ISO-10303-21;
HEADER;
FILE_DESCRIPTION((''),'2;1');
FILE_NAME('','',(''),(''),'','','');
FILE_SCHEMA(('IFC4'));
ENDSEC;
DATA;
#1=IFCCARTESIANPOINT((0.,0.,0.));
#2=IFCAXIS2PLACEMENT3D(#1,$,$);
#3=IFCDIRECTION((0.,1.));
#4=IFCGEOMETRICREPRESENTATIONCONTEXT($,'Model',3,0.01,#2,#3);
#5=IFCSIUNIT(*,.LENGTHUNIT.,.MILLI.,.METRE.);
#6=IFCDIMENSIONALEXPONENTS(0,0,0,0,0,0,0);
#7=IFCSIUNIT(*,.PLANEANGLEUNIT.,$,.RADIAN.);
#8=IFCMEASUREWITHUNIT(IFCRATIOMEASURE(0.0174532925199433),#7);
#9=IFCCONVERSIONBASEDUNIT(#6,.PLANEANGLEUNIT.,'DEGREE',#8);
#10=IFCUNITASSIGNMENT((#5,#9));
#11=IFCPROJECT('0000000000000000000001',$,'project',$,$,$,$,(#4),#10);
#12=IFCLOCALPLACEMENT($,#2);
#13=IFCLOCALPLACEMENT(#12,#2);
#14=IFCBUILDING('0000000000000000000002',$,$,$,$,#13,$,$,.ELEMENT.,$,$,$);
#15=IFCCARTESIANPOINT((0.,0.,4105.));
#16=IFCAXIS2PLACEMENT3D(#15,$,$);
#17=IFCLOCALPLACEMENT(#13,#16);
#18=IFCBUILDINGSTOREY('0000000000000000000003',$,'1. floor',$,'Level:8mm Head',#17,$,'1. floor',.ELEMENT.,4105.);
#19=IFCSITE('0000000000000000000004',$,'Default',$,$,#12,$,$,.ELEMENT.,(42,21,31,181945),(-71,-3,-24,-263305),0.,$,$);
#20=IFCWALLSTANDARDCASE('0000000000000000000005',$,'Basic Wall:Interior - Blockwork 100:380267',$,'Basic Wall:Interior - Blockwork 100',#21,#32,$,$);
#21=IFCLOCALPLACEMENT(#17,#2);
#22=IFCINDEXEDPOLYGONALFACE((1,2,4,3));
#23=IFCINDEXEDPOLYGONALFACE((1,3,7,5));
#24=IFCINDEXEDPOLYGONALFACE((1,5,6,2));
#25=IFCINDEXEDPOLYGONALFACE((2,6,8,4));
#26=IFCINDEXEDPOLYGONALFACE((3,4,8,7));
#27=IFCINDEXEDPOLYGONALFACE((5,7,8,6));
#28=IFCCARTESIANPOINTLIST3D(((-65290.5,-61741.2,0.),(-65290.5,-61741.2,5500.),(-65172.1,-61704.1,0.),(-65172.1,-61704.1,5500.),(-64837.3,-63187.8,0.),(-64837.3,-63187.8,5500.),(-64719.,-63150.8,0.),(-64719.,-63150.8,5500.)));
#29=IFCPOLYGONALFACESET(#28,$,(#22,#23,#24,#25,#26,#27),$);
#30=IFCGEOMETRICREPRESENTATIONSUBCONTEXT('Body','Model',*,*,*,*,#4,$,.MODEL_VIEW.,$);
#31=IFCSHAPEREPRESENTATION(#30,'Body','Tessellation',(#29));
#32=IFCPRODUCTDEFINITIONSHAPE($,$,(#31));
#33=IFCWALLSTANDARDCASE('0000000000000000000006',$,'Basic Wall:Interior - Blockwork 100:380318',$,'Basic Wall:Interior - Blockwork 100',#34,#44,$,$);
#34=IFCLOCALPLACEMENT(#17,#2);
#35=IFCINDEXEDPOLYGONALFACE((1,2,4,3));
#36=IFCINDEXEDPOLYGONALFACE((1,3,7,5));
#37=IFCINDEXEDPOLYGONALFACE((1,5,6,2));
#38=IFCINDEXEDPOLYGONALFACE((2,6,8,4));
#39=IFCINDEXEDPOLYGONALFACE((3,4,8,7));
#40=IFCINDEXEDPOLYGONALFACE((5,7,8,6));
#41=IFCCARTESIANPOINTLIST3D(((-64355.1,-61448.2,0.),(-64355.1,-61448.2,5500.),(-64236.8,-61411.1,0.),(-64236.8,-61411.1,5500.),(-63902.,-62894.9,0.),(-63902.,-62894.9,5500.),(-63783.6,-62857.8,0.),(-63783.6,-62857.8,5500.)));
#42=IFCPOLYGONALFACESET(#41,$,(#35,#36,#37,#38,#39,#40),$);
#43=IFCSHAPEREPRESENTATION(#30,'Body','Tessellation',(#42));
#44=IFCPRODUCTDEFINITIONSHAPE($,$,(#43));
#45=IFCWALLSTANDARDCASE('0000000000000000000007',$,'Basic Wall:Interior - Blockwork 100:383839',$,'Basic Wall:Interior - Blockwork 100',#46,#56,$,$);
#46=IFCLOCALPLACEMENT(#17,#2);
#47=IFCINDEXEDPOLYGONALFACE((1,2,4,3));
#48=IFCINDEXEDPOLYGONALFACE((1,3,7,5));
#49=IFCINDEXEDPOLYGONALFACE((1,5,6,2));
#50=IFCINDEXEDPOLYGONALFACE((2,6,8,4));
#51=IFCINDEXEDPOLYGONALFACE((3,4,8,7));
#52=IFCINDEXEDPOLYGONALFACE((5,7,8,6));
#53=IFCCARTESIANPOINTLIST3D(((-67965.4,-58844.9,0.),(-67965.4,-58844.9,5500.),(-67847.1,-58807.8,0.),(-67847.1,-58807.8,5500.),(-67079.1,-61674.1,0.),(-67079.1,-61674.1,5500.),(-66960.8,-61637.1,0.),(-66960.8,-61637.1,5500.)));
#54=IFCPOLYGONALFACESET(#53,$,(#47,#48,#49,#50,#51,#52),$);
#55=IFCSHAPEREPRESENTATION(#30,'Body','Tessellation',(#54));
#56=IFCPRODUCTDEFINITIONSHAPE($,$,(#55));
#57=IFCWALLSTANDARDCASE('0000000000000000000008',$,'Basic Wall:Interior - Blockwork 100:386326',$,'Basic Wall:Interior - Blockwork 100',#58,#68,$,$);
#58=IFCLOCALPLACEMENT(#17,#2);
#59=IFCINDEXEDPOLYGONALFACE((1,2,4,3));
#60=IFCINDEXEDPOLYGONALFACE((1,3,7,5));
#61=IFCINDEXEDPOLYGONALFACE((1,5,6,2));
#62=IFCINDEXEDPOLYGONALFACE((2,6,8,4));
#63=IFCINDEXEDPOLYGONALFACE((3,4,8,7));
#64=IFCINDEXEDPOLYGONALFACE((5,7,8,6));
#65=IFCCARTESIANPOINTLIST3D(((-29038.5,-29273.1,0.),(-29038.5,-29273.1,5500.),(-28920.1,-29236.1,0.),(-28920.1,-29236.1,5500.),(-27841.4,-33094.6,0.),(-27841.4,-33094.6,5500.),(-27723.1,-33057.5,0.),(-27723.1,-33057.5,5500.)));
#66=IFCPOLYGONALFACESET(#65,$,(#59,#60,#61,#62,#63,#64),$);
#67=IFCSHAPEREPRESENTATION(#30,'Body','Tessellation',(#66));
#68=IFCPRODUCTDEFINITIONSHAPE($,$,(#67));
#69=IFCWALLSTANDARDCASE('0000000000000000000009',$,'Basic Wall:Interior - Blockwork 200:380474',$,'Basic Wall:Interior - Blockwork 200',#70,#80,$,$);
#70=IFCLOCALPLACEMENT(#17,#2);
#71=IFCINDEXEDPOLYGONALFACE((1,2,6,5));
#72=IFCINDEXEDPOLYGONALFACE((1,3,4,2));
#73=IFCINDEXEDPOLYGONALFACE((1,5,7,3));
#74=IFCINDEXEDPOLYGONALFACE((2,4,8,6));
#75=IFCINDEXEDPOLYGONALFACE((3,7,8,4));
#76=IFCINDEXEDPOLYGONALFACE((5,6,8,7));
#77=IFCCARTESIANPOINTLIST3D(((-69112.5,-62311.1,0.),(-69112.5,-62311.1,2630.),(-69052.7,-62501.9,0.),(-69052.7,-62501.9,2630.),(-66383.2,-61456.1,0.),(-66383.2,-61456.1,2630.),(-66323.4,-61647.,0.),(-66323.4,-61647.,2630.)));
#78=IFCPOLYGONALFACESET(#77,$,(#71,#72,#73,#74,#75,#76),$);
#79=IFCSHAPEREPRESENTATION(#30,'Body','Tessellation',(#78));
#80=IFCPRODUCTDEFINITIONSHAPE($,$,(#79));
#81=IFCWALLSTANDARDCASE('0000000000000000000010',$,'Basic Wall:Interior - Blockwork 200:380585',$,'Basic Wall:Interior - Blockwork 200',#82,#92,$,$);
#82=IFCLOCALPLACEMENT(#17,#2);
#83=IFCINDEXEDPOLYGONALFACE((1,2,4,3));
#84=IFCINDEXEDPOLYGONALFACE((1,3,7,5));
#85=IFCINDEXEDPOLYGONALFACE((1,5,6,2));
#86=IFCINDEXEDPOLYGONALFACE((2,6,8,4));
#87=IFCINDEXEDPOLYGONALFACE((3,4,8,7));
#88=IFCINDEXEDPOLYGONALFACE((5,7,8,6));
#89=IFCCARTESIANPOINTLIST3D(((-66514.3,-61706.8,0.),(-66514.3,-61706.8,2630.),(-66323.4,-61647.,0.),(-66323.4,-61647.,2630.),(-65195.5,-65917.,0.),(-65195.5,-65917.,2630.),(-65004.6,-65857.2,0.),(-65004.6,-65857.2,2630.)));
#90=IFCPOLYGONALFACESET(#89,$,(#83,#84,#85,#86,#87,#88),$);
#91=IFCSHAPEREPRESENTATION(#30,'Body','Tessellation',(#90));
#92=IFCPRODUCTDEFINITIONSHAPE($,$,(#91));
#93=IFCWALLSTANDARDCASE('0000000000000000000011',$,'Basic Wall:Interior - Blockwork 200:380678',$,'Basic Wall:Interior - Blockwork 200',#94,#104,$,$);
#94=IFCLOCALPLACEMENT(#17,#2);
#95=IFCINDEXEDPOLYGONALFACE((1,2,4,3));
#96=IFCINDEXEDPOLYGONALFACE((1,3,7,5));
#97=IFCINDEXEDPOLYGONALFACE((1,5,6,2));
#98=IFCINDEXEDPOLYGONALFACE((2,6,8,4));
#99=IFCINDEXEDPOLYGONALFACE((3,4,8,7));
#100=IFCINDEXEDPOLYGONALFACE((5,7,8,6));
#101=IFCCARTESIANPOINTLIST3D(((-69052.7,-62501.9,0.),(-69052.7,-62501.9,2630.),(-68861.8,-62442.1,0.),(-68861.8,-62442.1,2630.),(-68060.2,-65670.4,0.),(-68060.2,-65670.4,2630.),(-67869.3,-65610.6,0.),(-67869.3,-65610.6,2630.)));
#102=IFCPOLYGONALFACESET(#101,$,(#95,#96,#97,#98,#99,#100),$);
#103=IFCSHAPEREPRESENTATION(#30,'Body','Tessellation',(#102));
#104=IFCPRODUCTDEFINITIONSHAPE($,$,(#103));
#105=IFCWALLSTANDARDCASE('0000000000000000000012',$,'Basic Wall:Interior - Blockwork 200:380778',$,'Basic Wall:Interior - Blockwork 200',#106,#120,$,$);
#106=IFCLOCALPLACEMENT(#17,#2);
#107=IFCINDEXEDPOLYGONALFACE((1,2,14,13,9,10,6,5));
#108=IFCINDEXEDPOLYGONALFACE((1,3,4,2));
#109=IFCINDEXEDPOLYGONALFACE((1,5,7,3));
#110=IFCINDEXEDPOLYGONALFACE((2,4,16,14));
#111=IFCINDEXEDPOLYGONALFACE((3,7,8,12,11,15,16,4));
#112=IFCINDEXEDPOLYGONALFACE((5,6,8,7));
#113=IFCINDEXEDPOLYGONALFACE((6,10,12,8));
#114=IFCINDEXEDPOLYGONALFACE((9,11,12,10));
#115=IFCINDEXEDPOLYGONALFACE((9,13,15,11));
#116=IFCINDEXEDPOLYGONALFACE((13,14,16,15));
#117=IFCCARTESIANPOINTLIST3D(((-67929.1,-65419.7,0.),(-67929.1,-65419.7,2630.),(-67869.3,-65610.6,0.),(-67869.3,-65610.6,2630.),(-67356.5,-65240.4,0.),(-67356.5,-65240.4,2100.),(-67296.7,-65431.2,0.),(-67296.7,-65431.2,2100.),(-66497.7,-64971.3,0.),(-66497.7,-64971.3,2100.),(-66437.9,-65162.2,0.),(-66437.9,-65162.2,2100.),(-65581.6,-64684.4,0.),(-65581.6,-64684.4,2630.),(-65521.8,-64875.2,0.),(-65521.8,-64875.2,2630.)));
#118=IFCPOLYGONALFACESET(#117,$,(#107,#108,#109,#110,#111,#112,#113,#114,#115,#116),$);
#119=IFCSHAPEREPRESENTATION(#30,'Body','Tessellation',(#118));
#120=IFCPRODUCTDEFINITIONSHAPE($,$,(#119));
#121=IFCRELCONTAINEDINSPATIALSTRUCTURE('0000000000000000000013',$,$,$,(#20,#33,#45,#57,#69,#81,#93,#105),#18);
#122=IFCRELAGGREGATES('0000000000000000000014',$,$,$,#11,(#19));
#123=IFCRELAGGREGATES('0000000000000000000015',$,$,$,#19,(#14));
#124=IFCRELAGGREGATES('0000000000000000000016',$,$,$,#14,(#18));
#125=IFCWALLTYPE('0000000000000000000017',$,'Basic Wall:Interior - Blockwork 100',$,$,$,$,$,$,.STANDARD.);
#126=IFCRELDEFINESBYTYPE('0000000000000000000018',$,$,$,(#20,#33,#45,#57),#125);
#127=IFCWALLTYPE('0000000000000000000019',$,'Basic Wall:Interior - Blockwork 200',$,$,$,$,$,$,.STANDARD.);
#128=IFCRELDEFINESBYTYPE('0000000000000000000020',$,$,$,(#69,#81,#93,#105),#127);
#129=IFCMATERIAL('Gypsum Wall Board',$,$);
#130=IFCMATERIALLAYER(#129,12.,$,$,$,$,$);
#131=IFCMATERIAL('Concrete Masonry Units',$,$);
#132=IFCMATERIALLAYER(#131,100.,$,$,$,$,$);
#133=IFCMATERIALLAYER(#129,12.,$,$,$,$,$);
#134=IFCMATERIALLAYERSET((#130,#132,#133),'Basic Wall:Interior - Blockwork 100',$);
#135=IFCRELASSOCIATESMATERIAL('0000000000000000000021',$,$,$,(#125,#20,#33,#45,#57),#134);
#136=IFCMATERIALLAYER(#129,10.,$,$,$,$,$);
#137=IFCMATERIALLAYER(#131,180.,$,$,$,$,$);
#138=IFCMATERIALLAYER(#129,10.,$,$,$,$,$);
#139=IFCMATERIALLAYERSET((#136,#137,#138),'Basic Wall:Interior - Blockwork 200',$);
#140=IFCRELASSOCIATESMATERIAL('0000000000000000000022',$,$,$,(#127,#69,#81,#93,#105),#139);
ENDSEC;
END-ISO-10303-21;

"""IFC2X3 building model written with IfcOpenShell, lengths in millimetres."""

from ifc_helpers import new_model, entity, si_unit, converted_unit, direction, frame, frame_2d, origin, place, context, subcontext, project, spatial, rectangle, extrude, material, layer, layer_set, layer_usage, type_object, element, save


model = new_model("IFC2X3")

# Units and contexts
model_context = context("Model", 3, precision=0.01, world=origin(), true_north=direction((0.0, 1.0)))
body_context = subcontext(model_context, "Body", "Model", "MODEL_VIEW")
ifc_project = project(units=[si_unit("LENGTHUNIT", "METRE", prefix="MILLI"), converted_unit("PLANEANGLEUNIT", "DEGREE", entity("IfcRatioMeasure", 0.0174532925199433), si_unit("PLANEANGLEUNIT", "RADIAN"), dimensions=[0, 0, 0, 0, 0, 0, 0])], contexts=[model_context])

# Site, building, storey
site_placement = place(None, origin())
site = spatial("IfcSite", under=ifc_project, at=site_placement, Name="Default", CompositionType="ELEMENT", RefLatitude=(42, 21, 31, 181945), RefLongitude=(-71, -3, -24, -263305), RefElevation=0.0)
building_placement = place(site_placement, origin())
building = spatial("IfcBuilding", under=site, at=building_placement, CompositionType="ELEMENT")
storey_placement = place(building_placement, frame((0.0, 0.0, 4105.0)))
storey = spatial("IfcBuildingStorey", under=building, at=storey_placement, Name="1. floor", ObjectType="Level:8mm Head", LongName="1. floor", CompositionType="ELEMENT", Elevation=4105.0)

# Shared definitions
ifc_material_1 = material(Name="Gypsum Wall Board")

# Shared definitions
ifc_layer_1 = layer(ifc_material_1, 12.0)
ifc_material_2 = material(Name="Concrete Masonry Units")
ifc_layer_2 = layer(ifc_material_2, 100.0)
ifc_layer_3 = layer(ifc_material_1, 12.0)
ifc_layer_set_1 = layer_set([ifc_layer_1, ifc_layer_2, ifc_layer_3], Name="Basic Wall:Interior - Blockwork 100")
wall_type_1 = type_object("IfcWallType", Name="Basic Wall:Interior - Blockwork 100", PredefinedType="STANDARD", material=ifc_layer_set_1)

# Walls
ifc_layer_usage_1 = layer_usage(ifc_layer_set_1, "AXIS2", "NEGATIVE", 62.0)
wall_1_placement = place(storey_placement, frame((-65231.3, -61722.6, 0.0), z_axis=(0.0, 0.0, 1.0), x_axis=(0.298924, -0.954277, 0.0)))
element("IfcWallStandardCase", 1, at=wall_1_placement, inside=storey, type_object=wall_type_1, material=ifc_layer_usage_1, Name="Basic Wall:Interior - Blockwork 100:380267", ObjectType="Basic Wall:Interior - Blockwork 100", context=body_context, shape_type="SweptSolid", body=[
    extrude(rectangle(XDim=1516.0, YDim=124.0, at=frame_2d((758.0, 0.0), x_axis=(-1.0, 0.0))), origin(), (0.0, 0.0, 1.0), 5500.0),
])
ifc_layer_usage_2 = layer_usage(ifc_layer_set_1, "AXIS2", "NEGATIVE", 62.0)
wall_2_placement = place(storey_placement, frame((-64296.0, -61429.6, 0.0), z_axis=(0.0, 0.0, 1.0), x_axis=(0.298924, -0.954277, 0.0)))
element("IfcWallStandardCase", 2, at=wall_2_placement, inside=storey, type_object=wall_type_1, material=ifc_layer_usage_2, Name="Basic Wall:Interior - Blockwork 100:380318", ObjectType="Basic Wall:Interior - Blockwork 100", context=body_context, shape_type="SweptSolid", body=[
    extrude(rectangle(XDim=1516.0, YDim=124.0, at=frame_2d((758.0, 0.0), x_axis=(-1.0, 0.0))), origin(), (0.0, 0.0, 1.0), 5500.0),
])
ifc_layer_usage_3 = layer_usage(ifc_layer_set_1, "AXIS2", "NEGATIVE", 62.0)
wall_3_placement = place(storey_placement, frame((-67906.2, -58826.3, 0.0), z_axis=(0.0, 0.0, 1.0), x_axis=(0.298924, -0.954277, 0.0)))
element("IfcWallStandardCase", 3, at=wall_3_placement, inside=storey, type_object=wall_type_1, material=ifc_layer_usage_3, Name="Basic Wall:Interior - Blockwork 100:383839", ObjectType="Basic Wall:Interior - Blockwork 100", context=body_context, shape_type="SweptSolid", body=[
    extrude(rectangle(XDim=2964.8, YDim=124.0, at=frame_2d((1482.4, 0.0), x_axis=(-1.0, 0.0))), origin(), (0.0, 0.0, 1.0), 5500.0),
])
ifc_layer_usage_4 = layer_usage(ifc_layer_set_1, "AXIS2", "NEGATIVE", 62.0)
wall_4_placement = place(storey_placement, frame((-28979.3, -29254.6, 0.0), z_axis=(0.0, 0.0, 1.0), x_axis=(0.298924, -0.954277, 0.0)))
element("IfcWallStandardCase", 4, at=wall_4_placement, inside=storey, type_object=wall_type_1, material=ifc_layer_usage_4, Name="Basic Wall:Interior - Blockwork 100:386326", ObjectType="Basic Wall:Interior - Blockwork 100", context=body_context, shape_type="SweptSolid", body=[
    extrude(rectangle(XDim=4004.5, YDim=124.0, at=frame_2d((2002.3, 0.0), x_axis=(-1.0, 0.0))), origin(), (0.0, 0.0, 1.0), 5500.0),
])
ifc_layer_4 = layer(ifc_material_1, 10.0)
ifc_layer_5 = layer(ifc_material_2, 180.0)
ifc_layer_6 = layer(ifc_material_1, 10.0)
ifc_layer_set_2 = layer_set([ifc_layer_4, ifc_layer_5, ifc_layer_6], Name="Basic Wall:Interior - Blockwork 200")
ifc_layer_usage_5 = layer_usage(ifc_layer_set_2, "AXIS2", "NEGATIVE", 100.0)
wall_type_2 = type_object("IfcWallType", Name="Basic Wall:Interior - Blockwork 200", PredefinedType="STANDARD", material=ifc_layer_set_2)
wall_5_placement = place(storey_placement, frame((-69082.6, -62406.5, 0.0), z_axis=(0.0, 0.0, 1.0), x_axis=(0.954277, 0.298924, 0.0)))
element("IfcWallStandardCase", 5, at=wall_5_placement, inside=storey, type_object=wall_type_2, material=ifc_layer_usage_5, Name="Basic Wall:Interior - Blockwork 200:380474", ObjectType="Basic Wall:Interior - Blockwork 200", context=body_context, shape_type="SweptSolid", body=[
    extrude(rectangle(XDim=2860.0, YDim=200.0, at=frame_2d((1430.0, 0.0), x_axis=(-1.0, 0.0))), origin(), (0.0, 0.0, 1.0), 2630.0),
])
ifc_layer_usage_6 = layer_usage(ifc_layer_set_2, "AXIS2", "NEGATIVE", 100.0)
wall_6_placement = place(storey_placement, frame((-66418.9, -61676.9, 0.0), z_axis=(0.0, 0.0, 1.0), x_axis=(0.298924, -0.954277, 0.0)))
element("IfcWallStandardCase", 6, at=wall_6_placement, inside=storey, type_object=wall_type_2, material=ifc_layer_usage_6, Name="Basic Wall:Interior - Blockwork 200:380585", ObjectType="Basic Wall:Interior - Blockwork 200", context=body_context, shape_type="SweptSolid", body=[
    extrude(rectangle(XDim=4412.0, YDim=200.0, at=frame_2d((2206.0, 0.0), x_axis=(-1.0, 0.0))), origin(), (0.0, 0.0, 1.0), 2630.0),
])
ifc_layer_usage_7 = layer_usage(ifc_layer_set_2, "AXIS2", "NEGATIVE", 100.0)
wall_7_placement = place(storey_placement, frame((-68957.2, -62472.0, 0.0), z_axis=(0.0, 0.0, 1.0), x_axis=(0.298924, -0.954277, 0.0)))
element("IfcWallStandardCase", 7, at=wall_7_placement, inside=storey, type_object=wall_type_2, material=ifc_layer_usage_7, Name="Basic Wall:Interior - Blockwork 200:380678", ObjectType="Basic Wall:Interior - Blockwork 200", context=body_context, shape_type="SweptSolid", body=[
    extrude(rectangle(XDim=3320.3, YDim=200.0, at=frame_2d((1660.1, 0.0), x_axis=(-1.0, 0.0))), origin(), (0.0, 0.0, 1.0), 2630.0),
])

# Wall, opening
ifc_layer_usage_8 = layer_usage(ifc_layer_set_2, "AXIS2", "NEGATIVE", 100.0)
wall_8_placement = place(storey_placement, frame((-65551.7, -64779.8, 0.0), z_axis=(0.0, 0.0, 1.0), x_axis=(-0.954277, -0.298924, 0.0)))
wall_8 = element("IfcWallStandardCase", 8, at=wall_8_placement, inside=storey, type_object=wall_type_2, material=ifc_layer_usage_8, Name="Basic Wall:Interior - Blockwork 200:380778", ObjectType="Basic Wall:Interior - Blockwork 200", context=body_context, shape_type="SweptSolid", body=[
    extrude(rectangle(XDim=2460.0, YDim=200.0, at=frame_2d((1230.0, 0.0), x_axis=(-1.0, 0.0))), origin(), (0.0, 0.0, 1.0), 2630.0),
])
opening_1_placement = place(wall_8_placement, origin())
element("IfcOpeningElement", 9, at=opening_1_placement, cuts=wall_8, ObjectType="Opening", context=body_context, shape_type="SweptSolid", body=[
    extrude(rectangle(XDim=2100.0, YDim=900.0, at=frame_2d((0.0, 0.0), x_axis=(0.0, 1.0))), frame((1410.0, -1624.0, 1050.0), z_axis=(0.0, 1.0, 0.0), x_axis=(-1.0, 0.0, 0.0)), (0.0, 0.0, 1.0), 3048.0),
])

save(model, "model.ifc")
